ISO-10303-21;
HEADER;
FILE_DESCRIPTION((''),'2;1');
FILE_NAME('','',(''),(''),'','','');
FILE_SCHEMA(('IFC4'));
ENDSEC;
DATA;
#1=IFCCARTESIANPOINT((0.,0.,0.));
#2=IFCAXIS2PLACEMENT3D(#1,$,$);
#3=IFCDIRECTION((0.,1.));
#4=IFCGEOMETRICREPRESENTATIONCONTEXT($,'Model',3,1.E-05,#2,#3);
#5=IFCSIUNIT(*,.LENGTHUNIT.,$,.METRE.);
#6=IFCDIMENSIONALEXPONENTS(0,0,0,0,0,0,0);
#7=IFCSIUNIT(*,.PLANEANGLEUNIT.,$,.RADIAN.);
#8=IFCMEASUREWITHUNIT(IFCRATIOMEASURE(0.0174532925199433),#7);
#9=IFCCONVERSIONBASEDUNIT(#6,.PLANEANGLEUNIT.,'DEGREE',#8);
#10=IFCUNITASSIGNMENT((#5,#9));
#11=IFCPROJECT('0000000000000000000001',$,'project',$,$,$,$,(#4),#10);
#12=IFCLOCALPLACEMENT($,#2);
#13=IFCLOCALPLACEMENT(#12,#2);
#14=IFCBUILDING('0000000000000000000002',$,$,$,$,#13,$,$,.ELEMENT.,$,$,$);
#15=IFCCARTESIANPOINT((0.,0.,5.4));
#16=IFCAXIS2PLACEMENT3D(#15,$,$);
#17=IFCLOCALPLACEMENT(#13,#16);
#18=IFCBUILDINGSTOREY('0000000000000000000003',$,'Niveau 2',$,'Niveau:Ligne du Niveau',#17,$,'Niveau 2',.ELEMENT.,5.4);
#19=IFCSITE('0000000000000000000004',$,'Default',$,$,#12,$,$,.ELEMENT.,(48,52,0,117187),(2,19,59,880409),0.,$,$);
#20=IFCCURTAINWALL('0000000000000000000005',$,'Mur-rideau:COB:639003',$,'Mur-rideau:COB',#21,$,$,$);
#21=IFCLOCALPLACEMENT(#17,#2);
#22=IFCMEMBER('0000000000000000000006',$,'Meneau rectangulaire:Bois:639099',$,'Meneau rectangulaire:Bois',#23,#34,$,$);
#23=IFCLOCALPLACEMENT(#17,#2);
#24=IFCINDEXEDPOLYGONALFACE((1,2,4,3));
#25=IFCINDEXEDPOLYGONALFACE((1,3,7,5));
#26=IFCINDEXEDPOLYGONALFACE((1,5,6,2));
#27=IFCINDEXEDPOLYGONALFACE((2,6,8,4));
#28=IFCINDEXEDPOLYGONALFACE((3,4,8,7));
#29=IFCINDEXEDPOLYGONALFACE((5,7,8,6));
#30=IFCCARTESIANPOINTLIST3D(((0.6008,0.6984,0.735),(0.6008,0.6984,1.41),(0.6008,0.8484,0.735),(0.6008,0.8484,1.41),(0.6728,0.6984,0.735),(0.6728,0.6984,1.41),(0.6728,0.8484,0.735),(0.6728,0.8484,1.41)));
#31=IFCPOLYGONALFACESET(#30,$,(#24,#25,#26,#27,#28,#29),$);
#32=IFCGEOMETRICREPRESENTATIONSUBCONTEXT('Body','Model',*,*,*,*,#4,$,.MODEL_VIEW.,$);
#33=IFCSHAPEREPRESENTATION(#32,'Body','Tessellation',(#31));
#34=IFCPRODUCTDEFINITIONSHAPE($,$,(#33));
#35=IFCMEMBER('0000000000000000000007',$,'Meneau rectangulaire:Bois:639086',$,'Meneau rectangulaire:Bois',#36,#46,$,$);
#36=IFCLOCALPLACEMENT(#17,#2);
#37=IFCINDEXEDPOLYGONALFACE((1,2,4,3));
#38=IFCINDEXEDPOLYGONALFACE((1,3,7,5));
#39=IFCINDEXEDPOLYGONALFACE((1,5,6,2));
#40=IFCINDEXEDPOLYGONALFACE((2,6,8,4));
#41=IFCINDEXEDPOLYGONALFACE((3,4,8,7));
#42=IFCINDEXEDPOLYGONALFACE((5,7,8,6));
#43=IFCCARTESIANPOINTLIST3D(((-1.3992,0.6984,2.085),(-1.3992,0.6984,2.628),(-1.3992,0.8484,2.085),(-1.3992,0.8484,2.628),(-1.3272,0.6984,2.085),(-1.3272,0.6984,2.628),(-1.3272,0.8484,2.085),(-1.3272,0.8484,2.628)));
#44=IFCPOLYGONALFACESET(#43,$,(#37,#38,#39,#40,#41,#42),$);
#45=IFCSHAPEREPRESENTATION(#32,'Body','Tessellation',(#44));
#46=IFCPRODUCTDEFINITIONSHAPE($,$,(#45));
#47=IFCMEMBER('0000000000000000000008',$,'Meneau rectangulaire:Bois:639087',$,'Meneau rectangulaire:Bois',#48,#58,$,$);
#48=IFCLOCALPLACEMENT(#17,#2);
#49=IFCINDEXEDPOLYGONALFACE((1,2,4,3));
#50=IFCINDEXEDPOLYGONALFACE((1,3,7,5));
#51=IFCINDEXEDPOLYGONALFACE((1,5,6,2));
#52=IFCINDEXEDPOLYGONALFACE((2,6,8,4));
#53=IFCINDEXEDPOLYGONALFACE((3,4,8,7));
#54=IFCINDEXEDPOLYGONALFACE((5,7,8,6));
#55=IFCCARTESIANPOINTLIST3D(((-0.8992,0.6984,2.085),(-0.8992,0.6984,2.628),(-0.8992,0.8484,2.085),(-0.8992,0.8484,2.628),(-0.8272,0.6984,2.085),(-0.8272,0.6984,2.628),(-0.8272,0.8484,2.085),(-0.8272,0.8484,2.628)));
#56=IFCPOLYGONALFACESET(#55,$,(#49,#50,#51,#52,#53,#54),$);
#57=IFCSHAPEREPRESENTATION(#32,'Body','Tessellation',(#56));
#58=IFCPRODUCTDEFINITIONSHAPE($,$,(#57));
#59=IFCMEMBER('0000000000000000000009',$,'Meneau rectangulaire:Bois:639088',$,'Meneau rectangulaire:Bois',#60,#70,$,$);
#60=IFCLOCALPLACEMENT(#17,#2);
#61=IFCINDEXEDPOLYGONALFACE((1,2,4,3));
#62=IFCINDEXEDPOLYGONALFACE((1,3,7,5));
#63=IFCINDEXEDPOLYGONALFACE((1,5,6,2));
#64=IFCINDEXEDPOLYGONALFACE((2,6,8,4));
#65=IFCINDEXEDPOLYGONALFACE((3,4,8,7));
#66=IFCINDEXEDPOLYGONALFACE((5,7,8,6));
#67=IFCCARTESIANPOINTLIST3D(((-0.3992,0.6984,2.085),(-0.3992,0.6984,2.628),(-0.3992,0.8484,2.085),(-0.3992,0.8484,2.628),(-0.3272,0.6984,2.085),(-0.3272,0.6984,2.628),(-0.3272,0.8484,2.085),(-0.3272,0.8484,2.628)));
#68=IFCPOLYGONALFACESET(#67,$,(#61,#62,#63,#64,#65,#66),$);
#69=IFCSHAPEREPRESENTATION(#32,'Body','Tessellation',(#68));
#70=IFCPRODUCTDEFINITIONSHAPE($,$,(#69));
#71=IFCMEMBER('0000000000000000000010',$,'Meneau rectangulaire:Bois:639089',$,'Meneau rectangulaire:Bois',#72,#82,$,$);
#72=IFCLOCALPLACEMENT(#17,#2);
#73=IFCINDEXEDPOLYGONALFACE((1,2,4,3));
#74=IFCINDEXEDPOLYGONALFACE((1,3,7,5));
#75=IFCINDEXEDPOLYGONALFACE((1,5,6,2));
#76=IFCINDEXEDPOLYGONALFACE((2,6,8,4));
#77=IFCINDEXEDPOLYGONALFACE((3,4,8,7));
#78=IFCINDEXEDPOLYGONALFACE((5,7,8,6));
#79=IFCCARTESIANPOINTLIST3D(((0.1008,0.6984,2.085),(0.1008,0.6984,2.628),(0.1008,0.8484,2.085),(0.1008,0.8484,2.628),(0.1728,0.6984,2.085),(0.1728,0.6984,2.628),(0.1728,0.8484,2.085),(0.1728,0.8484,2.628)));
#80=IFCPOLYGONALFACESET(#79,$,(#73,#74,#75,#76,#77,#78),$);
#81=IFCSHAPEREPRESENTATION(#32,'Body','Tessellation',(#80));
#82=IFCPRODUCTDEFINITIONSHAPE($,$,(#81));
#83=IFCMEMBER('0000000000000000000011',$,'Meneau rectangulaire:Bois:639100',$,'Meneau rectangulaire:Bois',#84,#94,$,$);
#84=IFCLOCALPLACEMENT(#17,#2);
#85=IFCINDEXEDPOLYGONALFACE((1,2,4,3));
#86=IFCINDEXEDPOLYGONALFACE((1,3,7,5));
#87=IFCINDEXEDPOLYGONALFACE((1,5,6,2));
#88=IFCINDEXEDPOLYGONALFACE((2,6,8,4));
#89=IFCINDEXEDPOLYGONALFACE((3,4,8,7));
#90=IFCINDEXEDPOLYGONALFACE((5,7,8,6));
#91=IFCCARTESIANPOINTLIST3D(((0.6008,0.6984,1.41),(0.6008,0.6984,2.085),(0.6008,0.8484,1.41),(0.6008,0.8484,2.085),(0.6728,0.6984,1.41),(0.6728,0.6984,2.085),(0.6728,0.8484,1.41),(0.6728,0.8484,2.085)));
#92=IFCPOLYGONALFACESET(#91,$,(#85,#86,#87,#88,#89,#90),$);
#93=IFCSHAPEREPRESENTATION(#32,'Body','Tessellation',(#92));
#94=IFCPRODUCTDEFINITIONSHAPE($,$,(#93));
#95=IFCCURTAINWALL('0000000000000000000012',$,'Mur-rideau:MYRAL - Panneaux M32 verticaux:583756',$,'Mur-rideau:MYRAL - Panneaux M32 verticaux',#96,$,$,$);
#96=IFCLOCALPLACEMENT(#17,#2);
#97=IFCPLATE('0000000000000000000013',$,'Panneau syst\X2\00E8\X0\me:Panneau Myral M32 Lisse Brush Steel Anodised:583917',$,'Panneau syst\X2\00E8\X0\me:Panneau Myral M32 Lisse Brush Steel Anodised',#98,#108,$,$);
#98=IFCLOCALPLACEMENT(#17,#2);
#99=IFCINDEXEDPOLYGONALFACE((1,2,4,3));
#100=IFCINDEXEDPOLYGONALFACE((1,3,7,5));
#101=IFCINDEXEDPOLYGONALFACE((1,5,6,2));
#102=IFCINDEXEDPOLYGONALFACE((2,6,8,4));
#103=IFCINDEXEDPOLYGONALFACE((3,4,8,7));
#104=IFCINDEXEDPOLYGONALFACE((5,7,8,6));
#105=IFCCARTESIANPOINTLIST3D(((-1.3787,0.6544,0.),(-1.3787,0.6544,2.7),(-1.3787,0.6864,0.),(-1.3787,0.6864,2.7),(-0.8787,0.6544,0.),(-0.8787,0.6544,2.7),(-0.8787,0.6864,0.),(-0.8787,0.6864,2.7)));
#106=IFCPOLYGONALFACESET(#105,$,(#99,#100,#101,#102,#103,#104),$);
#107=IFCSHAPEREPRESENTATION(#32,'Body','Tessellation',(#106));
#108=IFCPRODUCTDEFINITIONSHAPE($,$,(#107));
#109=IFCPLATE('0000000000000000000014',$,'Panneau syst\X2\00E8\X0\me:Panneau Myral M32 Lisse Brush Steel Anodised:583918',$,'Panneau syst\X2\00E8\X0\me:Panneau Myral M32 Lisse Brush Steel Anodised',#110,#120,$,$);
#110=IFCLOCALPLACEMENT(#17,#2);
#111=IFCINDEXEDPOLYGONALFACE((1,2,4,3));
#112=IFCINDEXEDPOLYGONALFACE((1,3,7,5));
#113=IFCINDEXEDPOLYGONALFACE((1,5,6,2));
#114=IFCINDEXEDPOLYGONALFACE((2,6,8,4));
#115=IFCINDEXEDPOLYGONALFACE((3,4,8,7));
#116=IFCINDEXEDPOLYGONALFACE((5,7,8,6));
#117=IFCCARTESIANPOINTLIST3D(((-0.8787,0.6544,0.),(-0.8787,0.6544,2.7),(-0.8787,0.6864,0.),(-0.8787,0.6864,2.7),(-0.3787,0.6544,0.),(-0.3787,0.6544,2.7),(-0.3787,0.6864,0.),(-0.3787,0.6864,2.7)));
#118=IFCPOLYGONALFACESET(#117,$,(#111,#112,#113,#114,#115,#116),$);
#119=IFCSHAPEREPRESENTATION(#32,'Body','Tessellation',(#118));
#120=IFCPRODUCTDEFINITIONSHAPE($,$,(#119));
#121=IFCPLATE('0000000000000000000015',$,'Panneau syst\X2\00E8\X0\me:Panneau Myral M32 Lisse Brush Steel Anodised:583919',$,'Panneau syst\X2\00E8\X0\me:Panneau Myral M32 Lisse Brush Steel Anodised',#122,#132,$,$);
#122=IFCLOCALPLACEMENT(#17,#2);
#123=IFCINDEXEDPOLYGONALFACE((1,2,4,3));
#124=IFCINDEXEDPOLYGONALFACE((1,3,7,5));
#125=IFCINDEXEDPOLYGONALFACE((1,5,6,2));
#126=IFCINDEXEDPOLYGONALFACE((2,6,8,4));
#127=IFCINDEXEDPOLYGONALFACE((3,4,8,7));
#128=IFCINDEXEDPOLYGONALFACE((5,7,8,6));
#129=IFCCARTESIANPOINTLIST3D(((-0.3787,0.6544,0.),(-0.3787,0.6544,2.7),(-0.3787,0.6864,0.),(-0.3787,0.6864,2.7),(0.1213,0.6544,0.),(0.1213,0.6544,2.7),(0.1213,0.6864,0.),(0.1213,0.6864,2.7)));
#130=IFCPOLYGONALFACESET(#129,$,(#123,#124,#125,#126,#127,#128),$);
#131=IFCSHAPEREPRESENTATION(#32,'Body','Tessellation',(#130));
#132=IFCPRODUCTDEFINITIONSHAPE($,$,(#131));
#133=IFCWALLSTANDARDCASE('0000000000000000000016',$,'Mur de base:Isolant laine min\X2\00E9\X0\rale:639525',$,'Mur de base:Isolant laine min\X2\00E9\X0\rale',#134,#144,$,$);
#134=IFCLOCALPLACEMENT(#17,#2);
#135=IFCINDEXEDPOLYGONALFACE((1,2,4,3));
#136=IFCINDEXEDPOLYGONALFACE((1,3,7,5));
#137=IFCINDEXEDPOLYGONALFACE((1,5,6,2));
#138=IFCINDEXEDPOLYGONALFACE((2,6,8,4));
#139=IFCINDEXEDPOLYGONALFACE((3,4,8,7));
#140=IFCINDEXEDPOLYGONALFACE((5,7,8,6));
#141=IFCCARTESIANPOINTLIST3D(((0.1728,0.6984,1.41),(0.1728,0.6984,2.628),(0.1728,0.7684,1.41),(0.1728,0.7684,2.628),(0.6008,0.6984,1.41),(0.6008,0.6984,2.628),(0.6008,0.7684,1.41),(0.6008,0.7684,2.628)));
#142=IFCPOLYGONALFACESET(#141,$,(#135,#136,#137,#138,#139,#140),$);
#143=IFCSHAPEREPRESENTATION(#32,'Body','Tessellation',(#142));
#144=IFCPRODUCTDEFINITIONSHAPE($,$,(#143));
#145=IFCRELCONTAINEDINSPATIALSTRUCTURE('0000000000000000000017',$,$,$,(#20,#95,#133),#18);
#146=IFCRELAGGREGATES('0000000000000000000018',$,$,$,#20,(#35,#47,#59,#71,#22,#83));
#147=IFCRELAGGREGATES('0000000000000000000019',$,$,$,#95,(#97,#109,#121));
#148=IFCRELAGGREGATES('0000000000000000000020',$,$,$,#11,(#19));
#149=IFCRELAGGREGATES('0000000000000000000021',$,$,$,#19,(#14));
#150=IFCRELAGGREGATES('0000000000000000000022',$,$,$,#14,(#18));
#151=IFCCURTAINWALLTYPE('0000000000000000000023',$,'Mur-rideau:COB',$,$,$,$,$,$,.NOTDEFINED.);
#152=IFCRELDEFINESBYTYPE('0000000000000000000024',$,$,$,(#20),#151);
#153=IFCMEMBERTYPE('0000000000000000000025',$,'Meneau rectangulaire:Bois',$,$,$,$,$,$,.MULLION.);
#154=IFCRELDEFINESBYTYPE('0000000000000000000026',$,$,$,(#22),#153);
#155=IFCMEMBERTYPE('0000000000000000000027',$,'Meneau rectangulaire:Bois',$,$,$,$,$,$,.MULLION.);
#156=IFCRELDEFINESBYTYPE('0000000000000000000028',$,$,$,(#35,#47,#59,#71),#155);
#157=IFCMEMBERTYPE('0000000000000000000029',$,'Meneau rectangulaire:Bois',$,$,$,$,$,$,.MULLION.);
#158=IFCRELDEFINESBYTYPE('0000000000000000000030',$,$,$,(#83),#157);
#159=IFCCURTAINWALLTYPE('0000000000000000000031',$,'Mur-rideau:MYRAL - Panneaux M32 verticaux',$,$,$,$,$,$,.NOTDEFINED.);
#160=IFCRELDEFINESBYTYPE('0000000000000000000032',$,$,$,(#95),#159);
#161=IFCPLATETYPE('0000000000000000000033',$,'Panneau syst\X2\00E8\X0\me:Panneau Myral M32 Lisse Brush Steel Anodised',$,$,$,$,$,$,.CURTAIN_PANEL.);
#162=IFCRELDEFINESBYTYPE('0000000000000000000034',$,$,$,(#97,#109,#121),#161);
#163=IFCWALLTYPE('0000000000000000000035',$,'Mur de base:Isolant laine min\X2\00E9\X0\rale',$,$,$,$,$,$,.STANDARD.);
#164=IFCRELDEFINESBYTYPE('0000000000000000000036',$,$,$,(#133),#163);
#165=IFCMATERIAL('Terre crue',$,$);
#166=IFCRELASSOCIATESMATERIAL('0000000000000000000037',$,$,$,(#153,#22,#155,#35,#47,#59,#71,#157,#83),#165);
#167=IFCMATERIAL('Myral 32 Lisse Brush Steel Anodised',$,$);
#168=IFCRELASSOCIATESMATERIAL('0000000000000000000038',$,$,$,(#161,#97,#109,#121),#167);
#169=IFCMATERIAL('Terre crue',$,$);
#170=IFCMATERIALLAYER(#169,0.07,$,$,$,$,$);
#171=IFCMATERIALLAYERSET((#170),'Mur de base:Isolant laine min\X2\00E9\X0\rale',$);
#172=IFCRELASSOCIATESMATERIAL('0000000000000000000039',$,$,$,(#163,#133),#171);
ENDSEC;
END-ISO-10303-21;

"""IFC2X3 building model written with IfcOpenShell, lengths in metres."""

from ifc_helpers import new_model, entity, si_unit, converted_unit, direction, frame, frame_2d, origin, origin_2d_with_axis, place, context, subcontext, project, spatial, rectangle, extrude, source, transform, mapped, material, layer, layer_set, layer_usage, type_object, type_shapes, element, aggregate, save


model = new_model("IFC2X3")

# Units and contexts
model_context = context("Model", 3, precision=1e-05, world=origin(), true_north=direction((0.0, 1.0)))
body_context = subcontext(model_context, "Body", "Model", "MODEL_VIEW")
ifc_project = project(units=[si_unit("LENGTHUNIT", "METRE"), converted_unit("PLANEANGLEUNIT", "DEGREE", entity("IfcRatioMeasure", 0.0174532925199433), si_unit("PLANEANGLEUNIT", "RADIAN"), dimensions=[0, 0, 0, 0, 0, 0, 0])], contexts=[model_context])

# Site, building, storey
site_placement = place(None, origin())
site = spatial("IfcSite", under=ifc_project, at=site_placement, Name="Default", CompositionType="ELEMENT", RefLatitude=(48, 52, 0, 117187), RefLongitude=(2, 19, 59, 880409), RefElevation=0.0)
building_placement = place(site_placement, origin())
building = spatial("IfcBuilding", under=site, at=building_placement, CompositionType="ELEMENT")
storey_placement = place(building_placement, frame((0.0, 0.0, 5.4)))
storey = spatial("IfcBuildingStorey", under=building, at=storey_placement, Name="Niveau 2", ObjectType="Niveau:Ligne du Niveau", LongName="Niveau 2", CompositionType="ELEMENT", Elevation=5.4)

# Curtain wall, members
curtain_wall_type_1 = type_object("IfcCurtainWallType", Name="Mur-rideau:COB", PredefinedType="NOTDEFINED")
curtain_wall_1_placement = place(storey_placement, frame((0.0, 0.0, -5.4)))
curtain_wall_1 = element("IfcCurtainWall", 1, at=curtain_wall_1_placement, inside=storey, type_object=curtain_wall_type_1, Name="Mur-rideau:COB:639003", ObjectType="Mur-rideau:COB")
ifc_material_1 = material(Name="Terre crue")
member_type_1 = type_object("IfcMemberType", Name="Meneau rectangulaire:Bois", PredefinedType="MULLION", material=ifc_material_1)
shared_shape_1 = source(origin(), body_context, "Body", "SweptSolid", [
    extrude(rectangle(XDim=0.15, YDim=0.072, at=origin_2d_with_axis()), frame((-0.024, 0.0, -0.675), z_axis=(0.0, 0.0, 1.0), x_axis=(0.0, -1.0, 0.0)), (0.0, 0.0, 1.0), 0.675),
])
type_shapes(member_type_1, [shared_shape_1])
member_1_placement = place(storey_placement, frame((0.6608, 0.7734, 0.735), z_axis=(0.0, 0.0, -1.0), x_axis=(1.0, 0.0, 0.0)))
member_1 = element("IfcMember", 2, at=member_1_placement, type_object=member_type_1, material=ifc_material_1, Name="Meneau rectangulaire:Bois:639099", ObjectType="Meneau rectangulaire:Bois", context=body_context, shape_type="MappedRepresentation", body=[
    mapped(shared_shape_1, transform((0.0, 0.0, 0.0), scale=1.0)),
])
member_type_2 = type_object("IfcMemberType", Name="Meneau rectangulaire:Bois", PredefinedType="MULLION", material=ifc_material_1)
shared_shape_2 = source(origin(), body_context, "Body", "SweptSolid", [
    extrude(rectangle(XDim=0.15, YDim=0.072, at=origin_2d_with_axis()), frame((-0.024, 0.0, -0.543), z_axis=(0.0, 0.0, 1.0), x_axis=(0.0, -1.0, 0.0)), (0.0, 0.0, 1.0), 0.543),
])
type_shapes(member_type_2, [shared_shape_2])
member_2_placement = place(storey_placement, frame((-1.3392, 0.7734, 2.085), z_axis=(0.0, 0.0, -1.0), x_axis=(1.0, 0.0, 0.0)))
member_2 = element("IfcMember", 3, at=member_2_placement, type_object=member_type_2, material=ifc_material_1, Name="Meneau rectangulaire:Bois:639086", ObjectType="Meneau rectangulaire:Bois", context=body_context, shape_type="MappedRepresentation", body=[
    mapped(shared_shape_2, transform((0.0, 0.0, 0.0), scale=1.0)),
])
member_3_placement = place(storey_placement, frame((-0.8392, 0.7734, 2.085), z_axis=(0.0, 0.0, -1.0), x_axis=(1.0, 0.0, 0.0)))
member_3 = element("IfcMember", 4, at=member_3_placement, type_object=member_type_2, material=ifc_material_1, Name="Meneau rectangulaire:Bois:639087", ObjectType="Meneau rectangulaire:Bois", context=body_context, shape_type="MappedRepresentation", body=[
    mapped(shared_shape_2, transform((0.0, 0.0, 0.0), scale=1.0)),
])
member_4_placement = place(storey_placement, frame((-0.3392, 0.7734, 2.085), z_axis=(0.0, 0.0, -1.0), x_axis=(1.0, 0.0, 0.0)))
member_4 = element("IfcMember", 5, at=member_4_placement, type_object=member_type_2, material=ifc_material_1, Name="Meneau rectangulaire:Bois:639088", ObjectType="Meneau rectangulaire:Bois", context=body_context, shape_type="MappedRepresentation", body=[
    mapped(shared_shape_2, transform((0.0, 0.0, 0.0), scale=1.0)),
])
member_5_placement = place(storey_placement, frame((0.1608, 0.7734, 2.085), z_axis=(0.0, 0.0, -1.0), x_axis=(1.0, 0.0, 0.0)))
member_5 = element("IfcMember", 6, at=member_5_placement, type_object=member_type_2, material=ifc_material_1, Name="Meneau rectangulaire:Bois:639089", ObjectType="Meneau rectangulaire:Bois", context=body_context, shape_type="MappedRepresentation", body=[
    mapped(shared_shape_2, transform((0.0, 0.0, 0.0), scale=1.0)),
])
member_type_3 = type_object("IfcMemberType", Name="Meneau rectangulaire:Bois", PredefinedType="MULLION", material=ifc_material_1)
shared_shape_3 = source(origin(), body_context, "Body", "SweptSolid", [
    extrude(rectangle(XDim=0.15, YDim=0.072, at=origin_2d_with_axis()), frame((-0.024, 0.0, -0.675), z_axis=(0.0, 0.0, 1.0), x_axis=(0.0, -1.0, 0.0)), (0.0, 0.0, 1.0), 0.675),
])
type_shapes(member_type_3, [shared_shape_3])
member_6_placement = place(storey_placement, frame((0.6608, 0.7734, 1.41), z_axis=(0.0, 0.0, -1.0), x_axis=(1.0, 0.0, 0.0)))
member_6 = element("IfcMember", 7, at=member_6_placement, type_object=member_type_3, material=ifc_material_1, Name="Meneau rectangulaire:Bois:639100", ObjectType="Meneau rectangulaire:Bois", context=body_context, shape_type="MappedRepresentation", body=[
    mapped(shared_shape_3, transform((0.0, 0.0, 0.0), scale=1.0)),
])
aggregate(curtain_wall_1, [member_2, member_3, member_4, member_5, member_1, member_6])

# Curtain wall, plates
curtain_wall_type_2 = type_object("IfcCurtainWallType", Name="Mur-rideau:MYRAL - Panneaux M32 verticaux", PredefinedType="NOTDEFINED")
curtain_wall_2_placement = place(storey_placement, frame((0.0, 0.0, -5.4)))
curtain_wall_2 = element("IfcCurtainWall", 8, at=curtain_wall_2_placement, inside=storey, type_object=curtain_wall_type_2, Name="Mur-rideau:MYRAL - Panneaux M32 verticaux:583756", ObjectType="Mur-rideau:MYRAL - Panneaux M32 verticaux")
ifc_material_2 = material(Name="Myral 32 Lisse Brush Steel Anodised")
plate_type = type_object("IfcPlateType", Name="Panneau système:Panneau Myral M32 Lisse Brush Steel Anodised", PredefinedType="CURTAIN_PANEL", material=ifc_material_2)
shared_shape_4 = source(origin(), body_context, "Body", "SweptSolid", [
    extrude(rectangle(XDim=0.032, YDim=0.5, at=origin_2d_with_axis()), frame((0.0, -0.016, 0.0), z_axis=(0.0, 0.0, 1.0), x_axis=(0.0, 1.0, 0.0)), (0.0, 0.0, 1.0), 2.7),
])
type_shapes(plate_type, [shared_shape_4])
plate_1_placement = place(curtain_wall_2_placement, frame((-1.1287, 0.6864, 5.4)))
plate_1 = element("IfcPlate", 9, at=plate_1_placement, type_object=plate_type, material=ifc_material_2, Name="Panneau système:Panneau Myral M32 Lisse Brush Steel Anodised:583917", ObjectType="Panneau système:Panneau Myral M32 Lisse Brush Steel Anodised", context=body_context, shape_type="MappedRepresentation", body=[
    mapped(shared_shape_4, transform((0.0, 0.0, 0.0), scale=1.0)),
])
plate_2_placement = place(curtain_wall_2_placement, frame((-0.6287, 0.6864, 5.4)))
plate_2 = element("IfcPlate", 10, at=plate_2_placement, type_object=plate_type, material=ifc_material_2, Name="Panneau système:Panneau Myral M32 Lisse Brush Steel Anodised:583918", ObjectType="Panneau système:Panneau Myral M32 Lisse Brush Steel Anodised", context=body_context, shape_type="MappedRepresentation", body=[
    mapped(shared_shape_4, transform((0.0, 0.0, 0.0), scale=1.0)),
])
plate_3_placement = place(curtain_wall_2_placement, frame((-0.1287, 0.6864, 5.4)))
plate_3 = element("IfcPlate", 11, at=plate_3_placement, type_object=plate_type, material=ifc_material_2, Name="Panneau système:Panneau Myral M32 Lisse Brush Steel Anodised:583919", ObjectType="Panneau système:Panneau Myral M32 Lisse Brush Steel Anodised", context=body_context, shape_type="MappedRepresentation", body=[
    mapped(shared_shape_4, transform((0.0, 0.0, 0.0), scale=1.0)),
])
aggregate(curtain_wall_2, [plate_1, plate_2, plate_3])

# Wall
ifc_material_3 = material(Name="Terre crue")
ifc_layer = layer(ifc_material_3, 0.07)
ifc_layer_set = layer_set([ifc_layer], Name="Mur de base:Isolant laine minérale")
ifc_layer_usage = layer_usage(ifc_layer_set, "AXIS2", "NEGATIVE", 0.035)
wall_type = type_object("IfcWallType", Name="Mur de base:Isolant laine minérale", PredefinedType="STANDARD", material=ifc_layer_set)
wall_placement = place(storey_placement, frame((0.1728, 0.7334, 1.41)))
element("IfcWallStandardCase", 12, at=wall_placement, inside=storey, type_object=wall_type, material=ifc_layer_usage, Name="Mur de base:Isolant laine minérale:639525", ObjectType="Mur de base:Isolant laine minérale", context=body_context, shape_type="SweptSolid", body=[
    extrude(rectangle(XDim=0.428, YDim=0.07, at=frame_2d((0.214, 0.0), x_axis=(-1.0, 0.0))), origin(), (0.0, 0.0, 1.0), 1.218),
])

save(model, "model.ifc")
